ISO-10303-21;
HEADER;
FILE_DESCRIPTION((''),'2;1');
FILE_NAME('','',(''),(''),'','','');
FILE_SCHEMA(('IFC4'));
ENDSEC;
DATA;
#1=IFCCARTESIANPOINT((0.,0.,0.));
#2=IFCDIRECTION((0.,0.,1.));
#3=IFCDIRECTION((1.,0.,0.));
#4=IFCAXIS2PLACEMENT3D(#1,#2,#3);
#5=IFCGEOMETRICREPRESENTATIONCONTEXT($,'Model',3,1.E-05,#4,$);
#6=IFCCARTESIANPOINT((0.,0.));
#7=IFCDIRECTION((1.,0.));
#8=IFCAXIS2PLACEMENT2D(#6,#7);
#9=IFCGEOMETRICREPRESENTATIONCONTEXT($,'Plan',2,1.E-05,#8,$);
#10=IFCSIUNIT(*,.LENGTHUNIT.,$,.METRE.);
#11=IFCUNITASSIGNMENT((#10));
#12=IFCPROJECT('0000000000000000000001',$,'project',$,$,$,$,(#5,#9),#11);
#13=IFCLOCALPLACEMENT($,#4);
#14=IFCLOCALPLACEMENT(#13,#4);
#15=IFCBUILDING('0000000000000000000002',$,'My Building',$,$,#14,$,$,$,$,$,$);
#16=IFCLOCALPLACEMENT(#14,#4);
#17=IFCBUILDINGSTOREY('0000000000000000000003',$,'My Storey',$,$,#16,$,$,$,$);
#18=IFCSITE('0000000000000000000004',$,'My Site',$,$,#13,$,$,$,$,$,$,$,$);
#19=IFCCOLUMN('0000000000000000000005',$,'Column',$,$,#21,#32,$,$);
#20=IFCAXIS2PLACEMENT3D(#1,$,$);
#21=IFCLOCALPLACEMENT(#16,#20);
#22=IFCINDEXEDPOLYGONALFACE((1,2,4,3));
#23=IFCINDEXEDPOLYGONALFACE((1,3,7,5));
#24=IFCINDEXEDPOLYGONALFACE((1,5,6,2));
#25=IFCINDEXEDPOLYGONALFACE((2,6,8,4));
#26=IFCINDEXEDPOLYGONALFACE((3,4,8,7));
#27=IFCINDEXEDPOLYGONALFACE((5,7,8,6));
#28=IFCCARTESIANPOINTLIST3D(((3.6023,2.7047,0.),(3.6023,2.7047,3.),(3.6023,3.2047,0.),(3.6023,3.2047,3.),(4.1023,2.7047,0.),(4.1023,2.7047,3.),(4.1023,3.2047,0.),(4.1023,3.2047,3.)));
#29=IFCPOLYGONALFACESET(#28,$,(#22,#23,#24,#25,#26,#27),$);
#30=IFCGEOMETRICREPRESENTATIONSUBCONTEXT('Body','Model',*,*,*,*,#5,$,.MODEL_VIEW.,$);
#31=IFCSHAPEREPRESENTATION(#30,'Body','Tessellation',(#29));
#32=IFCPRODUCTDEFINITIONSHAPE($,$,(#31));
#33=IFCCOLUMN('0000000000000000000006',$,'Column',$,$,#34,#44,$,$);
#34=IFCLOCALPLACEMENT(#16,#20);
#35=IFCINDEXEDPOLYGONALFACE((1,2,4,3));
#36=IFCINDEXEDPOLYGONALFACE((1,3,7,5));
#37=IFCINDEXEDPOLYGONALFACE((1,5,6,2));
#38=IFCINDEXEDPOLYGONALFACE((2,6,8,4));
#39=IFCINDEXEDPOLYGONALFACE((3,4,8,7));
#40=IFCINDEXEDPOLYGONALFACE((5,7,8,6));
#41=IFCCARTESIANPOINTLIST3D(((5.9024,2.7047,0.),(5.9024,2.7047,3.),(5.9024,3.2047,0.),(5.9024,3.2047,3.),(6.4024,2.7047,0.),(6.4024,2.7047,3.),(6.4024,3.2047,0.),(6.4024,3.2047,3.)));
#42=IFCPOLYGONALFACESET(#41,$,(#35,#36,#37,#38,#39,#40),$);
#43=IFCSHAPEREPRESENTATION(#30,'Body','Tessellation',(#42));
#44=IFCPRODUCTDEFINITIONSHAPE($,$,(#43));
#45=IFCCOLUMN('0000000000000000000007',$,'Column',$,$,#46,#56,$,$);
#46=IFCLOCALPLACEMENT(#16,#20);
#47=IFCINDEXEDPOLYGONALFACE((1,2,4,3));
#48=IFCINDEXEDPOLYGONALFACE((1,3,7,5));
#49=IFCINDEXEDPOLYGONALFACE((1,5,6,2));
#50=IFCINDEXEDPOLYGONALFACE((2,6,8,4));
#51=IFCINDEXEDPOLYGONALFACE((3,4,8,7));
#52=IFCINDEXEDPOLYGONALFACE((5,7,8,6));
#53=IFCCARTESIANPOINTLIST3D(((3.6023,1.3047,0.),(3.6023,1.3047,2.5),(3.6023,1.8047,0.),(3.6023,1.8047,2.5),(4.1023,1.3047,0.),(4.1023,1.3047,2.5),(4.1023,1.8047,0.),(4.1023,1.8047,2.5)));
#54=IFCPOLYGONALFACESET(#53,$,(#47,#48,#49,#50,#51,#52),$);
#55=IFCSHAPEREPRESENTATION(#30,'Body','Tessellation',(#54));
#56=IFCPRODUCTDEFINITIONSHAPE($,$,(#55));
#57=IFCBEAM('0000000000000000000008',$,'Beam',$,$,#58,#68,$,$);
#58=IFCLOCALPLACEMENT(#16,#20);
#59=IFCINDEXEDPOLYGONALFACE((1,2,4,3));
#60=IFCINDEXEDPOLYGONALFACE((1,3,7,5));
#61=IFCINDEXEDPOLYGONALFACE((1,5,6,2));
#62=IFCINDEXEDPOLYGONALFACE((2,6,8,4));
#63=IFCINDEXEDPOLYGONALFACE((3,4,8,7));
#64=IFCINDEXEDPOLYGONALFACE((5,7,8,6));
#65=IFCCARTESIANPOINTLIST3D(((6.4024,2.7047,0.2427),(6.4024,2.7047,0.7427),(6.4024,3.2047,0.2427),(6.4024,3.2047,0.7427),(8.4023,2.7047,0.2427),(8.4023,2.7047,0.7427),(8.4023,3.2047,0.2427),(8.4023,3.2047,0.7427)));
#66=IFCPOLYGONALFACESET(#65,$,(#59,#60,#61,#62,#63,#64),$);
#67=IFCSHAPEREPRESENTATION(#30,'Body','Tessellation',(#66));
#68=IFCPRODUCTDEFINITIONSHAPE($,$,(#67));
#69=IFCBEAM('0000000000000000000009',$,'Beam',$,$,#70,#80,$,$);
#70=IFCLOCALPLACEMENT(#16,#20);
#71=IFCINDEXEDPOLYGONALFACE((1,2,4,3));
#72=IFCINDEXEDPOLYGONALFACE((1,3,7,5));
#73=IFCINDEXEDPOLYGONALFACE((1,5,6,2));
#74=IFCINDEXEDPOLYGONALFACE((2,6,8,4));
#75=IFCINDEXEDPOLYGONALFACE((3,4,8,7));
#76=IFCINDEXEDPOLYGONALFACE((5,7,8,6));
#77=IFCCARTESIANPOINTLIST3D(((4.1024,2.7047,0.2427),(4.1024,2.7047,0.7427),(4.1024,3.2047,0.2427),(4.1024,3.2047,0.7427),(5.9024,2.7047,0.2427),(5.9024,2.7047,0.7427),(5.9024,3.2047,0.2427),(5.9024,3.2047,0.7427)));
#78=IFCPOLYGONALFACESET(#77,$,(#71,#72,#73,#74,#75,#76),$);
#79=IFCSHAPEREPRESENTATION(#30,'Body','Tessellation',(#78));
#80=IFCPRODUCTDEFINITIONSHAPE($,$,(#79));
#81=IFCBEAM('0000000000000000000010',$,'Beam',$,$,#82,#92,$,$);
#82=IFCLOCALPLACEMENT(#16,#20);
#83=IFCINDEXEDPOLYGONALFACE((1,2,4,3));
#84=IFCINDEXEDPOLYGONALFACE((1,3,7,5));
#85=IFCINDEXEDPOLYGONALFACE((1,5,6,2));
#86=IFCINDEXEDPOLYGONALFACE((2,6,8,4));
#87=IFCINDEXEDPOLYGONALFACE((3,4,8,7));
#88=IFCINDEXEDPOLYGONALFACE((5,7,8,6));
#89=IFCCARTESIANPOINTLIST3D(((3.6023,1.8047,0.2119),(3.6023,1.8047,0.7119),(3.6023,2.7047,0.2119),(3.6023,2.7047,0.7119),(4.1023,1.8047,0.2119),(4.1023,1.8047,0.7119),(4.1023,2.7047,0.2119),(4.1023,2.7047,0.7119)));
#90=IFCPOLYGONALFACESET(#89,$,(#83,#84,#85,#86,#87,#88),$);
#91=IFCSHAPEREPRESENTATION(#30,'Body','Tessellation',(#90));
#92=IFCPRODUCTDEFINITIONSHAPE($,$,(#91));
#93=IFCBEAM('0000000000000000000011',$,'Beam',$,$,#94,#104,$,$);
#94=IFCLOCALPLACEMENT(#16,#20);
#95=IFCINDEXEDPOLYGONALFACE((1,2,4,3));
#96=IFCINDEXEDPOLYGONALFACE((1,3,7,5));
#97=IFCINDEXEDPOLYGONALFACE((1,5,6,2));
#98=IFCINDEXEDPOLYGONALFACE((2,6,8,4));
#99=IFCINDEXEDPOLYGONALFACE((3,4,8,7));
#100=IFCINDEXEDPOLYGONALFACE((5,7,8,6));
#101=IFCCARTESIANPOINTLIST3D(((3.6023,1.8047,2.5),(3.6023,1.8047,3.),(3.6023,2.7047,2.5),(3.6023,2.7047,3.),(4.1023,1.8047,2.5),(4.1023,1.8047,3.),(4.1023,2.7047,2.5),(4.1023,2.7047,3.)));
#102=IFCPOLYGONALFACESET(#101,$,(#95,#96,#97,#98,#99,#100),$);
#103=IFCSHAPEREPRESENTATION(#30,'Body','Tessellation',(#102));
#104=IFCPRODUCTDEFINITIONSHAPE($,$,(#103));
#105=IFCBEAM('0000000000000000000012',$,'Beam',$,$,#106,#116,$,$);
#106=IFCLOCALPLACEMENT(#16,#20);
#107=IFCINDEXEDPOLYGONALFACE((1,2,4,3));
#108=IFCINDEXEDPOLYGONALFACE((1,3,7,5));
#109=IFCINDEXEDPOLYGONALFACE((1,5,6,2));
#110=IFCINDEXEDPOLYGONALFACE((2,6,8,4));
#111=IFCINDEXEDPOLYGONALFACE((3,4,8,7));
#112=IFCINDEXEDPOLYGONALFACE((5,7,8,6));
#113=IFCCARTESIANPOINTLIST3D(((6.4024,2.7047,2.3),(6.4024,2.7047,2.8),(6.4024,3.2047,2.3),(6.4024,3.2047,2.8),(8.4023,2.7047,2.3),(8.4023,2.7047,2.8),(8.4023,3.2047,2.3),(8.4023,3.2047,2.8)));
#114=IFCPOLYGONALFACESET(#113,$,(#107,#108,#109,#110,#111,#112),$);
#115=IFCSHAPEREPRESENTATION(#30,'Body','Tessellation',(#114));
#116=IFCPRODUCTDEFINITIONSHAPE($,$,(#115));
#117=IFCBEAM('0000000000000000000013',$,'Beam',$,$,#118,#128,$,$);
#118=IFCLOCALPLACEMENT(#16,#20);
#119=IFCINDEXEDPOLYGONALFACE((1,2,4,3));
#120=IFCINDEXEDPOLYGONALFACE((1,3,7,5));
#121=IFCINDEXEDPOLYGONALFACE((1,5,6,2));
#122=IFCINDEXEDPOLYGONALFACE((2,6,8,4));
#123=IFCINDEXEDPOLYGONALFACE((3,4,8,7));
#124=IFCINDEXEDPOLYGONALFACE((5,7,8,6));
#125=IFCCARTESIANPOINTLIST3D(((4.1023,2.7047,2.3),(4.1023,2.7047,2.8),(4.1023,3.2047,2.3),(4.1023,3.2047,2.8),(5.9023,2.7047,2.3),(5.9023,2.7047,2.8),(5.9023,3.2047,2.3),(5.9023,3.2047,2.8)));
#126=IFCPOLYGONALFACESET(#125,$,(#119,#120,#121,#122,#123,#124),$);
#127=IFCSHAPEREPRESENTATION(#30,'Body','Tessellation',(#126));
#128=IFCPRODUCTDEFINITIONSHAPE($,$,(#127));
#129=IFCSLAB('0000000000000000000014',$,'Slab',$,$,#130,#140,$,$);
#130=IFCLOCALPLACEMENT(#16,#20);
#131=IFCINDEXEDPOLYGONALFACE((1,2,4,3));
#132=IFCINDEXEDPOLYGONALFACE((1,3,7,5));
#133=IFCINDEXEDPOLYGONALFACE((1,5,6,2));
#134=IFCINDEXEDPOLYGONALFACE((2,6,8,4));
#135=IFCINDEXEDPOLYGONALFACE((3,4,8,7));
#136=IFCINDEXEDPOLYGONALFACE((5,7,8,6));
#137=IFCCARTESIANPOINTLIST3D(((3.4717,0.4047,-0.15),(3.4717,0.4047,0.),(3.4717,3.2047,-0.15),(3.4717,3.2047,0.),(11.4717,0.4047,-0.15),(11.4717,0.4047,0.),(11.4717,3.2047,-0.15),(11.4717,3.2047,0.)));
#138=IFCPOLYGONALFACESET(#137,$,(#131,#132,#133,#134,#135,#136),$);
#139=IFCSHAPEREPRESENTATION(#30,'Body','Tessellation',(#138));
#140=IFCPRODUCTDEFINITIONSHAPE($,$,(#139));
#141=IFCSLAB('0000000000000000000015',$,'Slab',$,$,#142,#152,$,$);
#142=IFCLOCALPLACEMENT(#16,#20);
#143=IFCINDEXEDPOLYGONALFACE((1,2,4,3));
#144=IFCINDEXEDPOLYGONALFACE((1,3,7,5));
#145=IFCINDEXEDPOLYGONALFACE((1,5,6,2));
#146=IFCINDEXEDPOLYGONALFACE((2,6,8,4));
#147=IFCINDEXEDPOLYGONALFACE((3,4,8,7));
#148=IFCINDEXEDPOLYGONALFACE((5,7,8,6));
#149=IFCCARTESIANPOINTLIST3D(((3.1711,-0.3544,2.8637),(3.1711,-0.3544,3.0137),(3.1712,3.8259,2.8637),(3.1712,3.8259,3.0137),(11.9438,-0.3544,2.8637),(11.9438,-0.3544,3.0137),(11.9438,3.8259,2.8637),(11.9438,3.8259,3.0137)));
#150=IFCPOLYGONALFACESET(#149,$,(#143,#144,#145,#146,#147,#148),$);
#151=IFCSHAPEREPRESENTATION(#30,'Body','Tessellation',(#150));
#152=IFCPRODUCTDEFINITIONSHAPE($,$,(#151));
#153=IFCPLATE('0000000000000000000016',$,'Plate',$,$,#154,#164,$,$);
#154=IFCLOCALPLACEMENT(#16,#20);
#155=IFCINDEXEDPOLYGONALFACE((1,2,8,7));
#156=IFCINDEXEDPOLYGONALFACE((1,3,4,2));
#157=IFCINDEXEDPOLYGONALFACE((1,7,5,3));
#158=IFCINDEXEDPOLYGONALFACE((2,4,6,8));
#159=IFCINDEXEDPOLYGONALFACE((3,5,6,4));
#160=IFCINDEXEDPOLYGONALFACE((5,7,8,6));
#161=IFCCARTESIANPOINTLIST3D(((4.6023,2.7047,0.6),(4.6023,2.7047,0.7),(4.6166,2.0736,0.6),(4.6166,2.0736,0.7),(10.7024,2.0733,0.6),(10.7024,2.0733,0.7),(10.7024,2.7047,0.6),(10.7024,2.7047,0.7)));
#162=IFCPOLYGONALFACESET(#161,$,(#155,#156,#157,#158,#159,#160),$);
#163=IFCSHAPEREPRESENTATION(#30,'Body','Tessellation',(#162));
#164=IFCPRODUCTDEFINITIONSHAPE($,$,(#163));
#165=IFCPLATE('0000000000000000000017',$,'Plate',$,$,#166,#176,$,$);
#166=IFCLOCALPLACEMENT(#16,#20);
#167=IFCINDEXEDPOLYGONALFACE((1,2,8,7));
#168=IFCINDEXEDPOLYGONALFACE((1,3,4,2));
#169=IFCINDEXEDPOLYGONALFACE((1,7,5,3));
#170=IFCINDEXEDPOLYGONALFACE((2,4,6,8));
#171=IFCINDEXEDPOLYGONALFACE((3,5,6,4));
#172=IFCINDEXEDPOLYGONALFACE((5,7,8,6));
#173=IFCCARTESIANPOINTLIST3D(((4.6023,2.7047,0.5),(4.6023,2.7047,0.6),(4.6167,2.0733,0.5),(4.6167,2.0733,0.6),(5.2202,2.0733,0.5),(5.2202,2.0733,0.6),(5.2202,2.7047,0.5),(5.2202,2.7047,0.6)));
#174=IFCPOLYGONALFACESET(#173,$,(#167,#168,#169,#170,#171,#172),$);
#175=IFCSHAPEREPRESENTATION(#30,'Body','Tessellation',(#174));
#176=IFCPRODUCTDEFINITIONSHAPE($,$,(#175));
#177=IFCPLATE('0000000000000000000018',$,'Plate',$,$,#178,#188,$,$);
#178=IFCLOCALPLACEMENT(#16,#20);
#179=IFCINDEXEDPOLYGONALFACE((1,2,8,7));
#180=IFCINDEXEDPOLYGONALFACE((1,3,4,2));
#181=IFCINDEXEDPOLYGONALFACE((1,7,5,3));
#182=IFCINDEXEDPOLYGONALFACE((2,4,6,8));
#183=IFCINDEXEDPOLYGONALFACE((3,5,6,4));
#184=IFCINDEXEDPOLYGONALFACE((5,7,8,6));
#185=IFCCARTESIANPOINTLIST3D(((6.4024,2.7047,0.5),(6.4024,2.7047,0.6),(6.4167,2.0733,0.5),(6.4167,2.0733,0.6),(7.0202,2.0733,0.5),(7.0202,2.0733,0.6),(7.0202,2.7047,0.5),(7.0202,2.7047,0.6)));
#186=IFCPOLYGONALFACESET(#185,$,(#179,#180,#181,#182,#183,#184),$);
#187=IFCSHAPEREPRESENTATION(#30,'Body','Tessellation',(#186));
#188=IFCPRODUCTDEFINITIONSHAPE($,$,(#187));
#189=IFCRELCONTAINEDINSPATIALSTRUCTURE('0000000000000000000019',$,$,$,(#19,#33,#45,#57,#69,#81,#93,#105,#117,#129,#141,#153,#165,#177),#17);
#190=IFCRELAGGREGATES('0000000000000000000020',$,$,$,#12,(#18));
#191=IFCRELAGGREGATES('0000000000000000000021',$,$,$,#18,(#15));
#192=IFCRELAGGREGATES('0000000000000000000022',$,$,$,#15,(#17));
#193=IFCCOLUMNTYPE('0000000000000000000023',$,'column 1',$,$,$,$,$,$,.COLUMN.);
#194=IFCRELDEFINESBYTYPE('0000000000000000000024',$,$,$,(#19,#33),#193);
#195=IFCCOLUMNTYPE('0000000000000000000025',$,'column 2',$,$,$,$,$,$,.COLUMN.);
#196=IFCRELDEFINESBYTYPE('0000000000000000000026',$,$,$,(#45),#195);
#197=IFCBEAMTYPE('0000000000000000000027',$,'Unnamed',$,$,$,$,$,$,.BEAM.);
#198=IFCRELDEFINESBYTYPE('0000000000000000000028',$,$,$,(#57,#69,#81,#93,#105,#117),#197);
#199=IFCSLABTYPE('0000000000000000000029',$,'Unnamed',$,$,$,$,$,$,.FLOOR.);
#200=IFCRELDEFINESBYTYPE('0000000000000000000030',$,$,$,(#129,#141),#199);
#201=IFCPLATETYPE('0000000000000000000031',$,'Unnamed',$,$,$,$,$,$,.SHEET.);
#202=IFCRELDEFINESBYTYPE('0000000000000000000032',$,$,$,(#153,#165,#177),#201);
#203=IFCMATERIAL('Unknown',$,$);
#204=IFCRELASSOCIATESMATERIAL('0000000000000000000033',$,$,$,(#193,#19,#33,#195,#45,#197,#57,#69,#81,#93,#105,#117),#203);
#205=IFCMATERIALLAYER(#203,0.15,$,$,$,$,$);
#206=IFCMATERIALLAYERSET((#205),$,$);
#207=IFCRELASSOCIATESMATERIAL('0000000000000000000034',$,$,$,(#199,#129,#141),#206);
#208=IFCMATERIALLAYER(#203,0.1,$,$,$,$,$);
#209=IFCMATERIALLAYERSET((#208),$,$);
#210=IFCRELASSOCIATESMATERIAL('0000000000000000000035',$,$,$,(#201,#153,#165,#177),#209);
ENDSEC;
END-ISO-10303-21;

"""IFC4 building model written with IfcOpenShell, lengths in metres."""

from ifc_helpers import new_model, si_unit, frame, origin_with_axes, origin_2d_with_axis, place, context, subcontext, project, spatial, indexed_curve, rectangle, outline, extrude, material, layer, layer_set, layer_usage, material_profile, profile_set, profile_usage, type_object, element, save


model = new_model("IFC4")

# Units and contexts
model_context = context("Model", 3, precision=1e-05, world=origin_with_axes())
plan_context = context("Plan", 2, precision=1e-05, world=origin_2d_with_axis())
body_context = subcontext(model_context, "Body", "Model", "MODEL_VIEW")
ifc_project = project(units=[si_unit("LENGTHUNIT", "METRE")], contexts=[model_context, plan_context])

# Site, building, storey
site_placement = place(None, origin_with_axes())
site = spatial("IfcSite", under=ifc_project, at=site_placement, Name="My Site")
building_placement = place(site_placement, origin_with_axes())
building = spatial("IfcBuilding", under=site, at=building_placement, Name="My Building")
storey_placement = place(building_placement, origin_with_axes())
storey = spatial("IfcBuildingStorey", under=building, at=storey_placement, Name="My Storey")

# Columns
ifc_material = material(Name="Unknown")
ifc_material_profile_1 = material_profile(ifc_material, rectangle(XDim=0.5, YDim=0.5))
ifc_profile_set_1 = profile_set([ifc_material_profile_1])
ifc_profile_usage_1 = profile_usage(ifc_profile_set_1, cardinal=5)
column_type_1 = type_object("IfcColumnType", Name="column 1", PredefinedType="COLUMN", material=ifc_profile_set_1)
column_1_placement = place(storey_placement, frame((3.8523, 2.9547, 0.0), z_axis=(0.0, 0.0, 1.0), x_axis=(1.0, 0.0, 0.0)))
element("IfcColumn", 1, at=column_1_placement, inside=storey, type_object=column_type_1, material=ifc_profile_usage_1, Name="Column", context=body_context, shape_type="SweptSolid", body=[
    extrude(rectangle(XDim=0.5, YDim=0.5), origin_with_axes(), (0.0, 0.0, 1.0), 3.0),
])
ifc_profile_usage_2 = profile_usage(ifc_profile_set_1, cardinal=5)
column_2_placement = place(storey_placement, frame((6.1524, 2.9547, 0.0), z_axis=(0.0, 0.0, 1.0), x_axis=(1.0, 0.0, 0.0)))
element("IfcColumn", 2, at=column_2_placement, inside=storey, type_object=column_type_1, material=ifc_profile_usage_2, Name="Column", context=body_context, shape_type="SweptSolid", body=[
    extrude(rectangle(XDim=0.5, YDim=0.5), origin_with_axes(), (0.0, 0.0, 1.0), 3.0),
])
ifc_material_profile_2 = material_profile(ifc_material, rectangle(XDim=0.5, YDim=0.5))
ifc_profile_set_2 = profile_set([ifc_material_profile_2])
ifc_profile_usage_3 = profile_usage(ifc_profile_set_2, cardinal=5)
column_type_2 = type_object("IfcColumnType", Name="column 2", PredefinedType="COLUMN", material=ifc_profile_set_2)
column_3_placement = place(storey_placement, frame((3.8523, 1.5547, 0.0), z_axis=(0.0, 0.0, 1.0), x_axis=(1.0, 0.0, 0.0)))
element("IfcColumn", 3, at=column_3_placement, inside=storey, type_object=column_type_2, material=ifc_profile_usage_3, Name="Column", context=body_context, shape_type="SweptSolid", body=[
    extrude(rectangle(XDim=0.5, YDim=0.5), origin_with_axes(), (0.0, 0.0, 1.0), 2.5),
])

# Beams
ifc_material_profile_3 = material_profile(ifc_material, rectangle(XDim=0.5, YDim=0.5))
ifc_profile_set_3 = profile_set([ifc_material_profile_3])
ifc_profile_usage_4 = profile_usage(ifc_profile_set_3, cardinal=5)
beam_type = type_object("IfcBeamType", Name="Unnamed", PredefinedType="BEAM", material=ifc_profile_set_3)
beam_1_placement = place(storey_placement, frame((6.4024, 2.9547, 0.4927), z_axis=(1.0, 0.0, 0.0), x_axis=(0.0, 1.0, 0.0)))
element("IfcBeam", 4, at=beam_1_placement, inside=storey, type_object=beam_type, material=ifc_profile_usage_4, Name="Beam", context=body_context, shape_type="SweptSolid", body=[
    extrude(rectangle(XDim=0.5, YDim=0.5), origin_with_axes(), (0.0, 0.0, 1.0), 2.0),
])
ifc_profile_usage_5 = profile_usage(ifc_profile_set_3, cardinal=5)
beam_2_placement = place(storey_placement, frame((5.9024, 2.9547, 0.4927), z_axis=(-1.0, 0.0, 0.0), x_axis=(0.0, -1.0, 0.0)))
element("IfcBeam", 5, at=beam_2_placement, inside=storey, type_object=beam_type, material=ifc_profile_usage_5, Name="Beam", context=body_context, shape_type="SweptSolid", body=[
    extrude(rectangle(XDim=0.5, YDim=0.5), origin_with_axes(), (0.0, 0.0, 1.0), 1.8),
])
ifc_profile_usage_6 = profile_usage(ifc_profile_set_3, cardinal=5)
beam_3_placement = place(storey_placement, frame((3.8523, 2.7047, 0.4619), z_axis=(0.0, -1.0, 0.0), x_axis=(1.0, 0.0, 0.0)))
element("IfcBeam", 6, at=beam_3_placement, inside=storey, type_object=beam_type, material=ifc_profile_usage_6, Name="Beam", context=body_context, shape_type="SweptSolid", body=[
    extrude(rectangle(XDim=0.5, YDim=0.5), origin_with_axes(), (0.0, 0.0, 1.0), 0.9),
])
ifc_profile_usage_7 = profile_usage(ifc_profile_set_3, cardinal=5)
beam_4_placement = place(storey_placement, frame((3.8523, 2.7047, 2.75), z_axis=(0.0, -1.0, 0.0), x_axis=(1.0, 0.0, 0.0)))
element("IfcBeam", 7, at=beam_4_placement, inside=storey, type_object=beam_type, material=ifc_profile_usage_7, Name="Beam", context=body_context, shape_type="SweptSolid", body=[
    extrude(rectangle(XDim=0.5, YDim=0.5), origin_with_axes(), (0.0, 0.0, 1.0), 0.9),
])
ifc_profile_usage_8 = profile_usage(ifc_profile_set_3, cardinal=5)
beam_5_placement = place(storey_placement, frame((6.4024, 2.9547, 2.55), z_axis=(1.0, 0.0, 0.0), x_axis=(0.0, 1.0, 0.0)))
element("IfcBeam", 8, at=beam_5_placement, inside=storey, type_object=beam_type, material=ifc_profile_usage_8, Name="Beam", context=body_context, shape_type="SweptSolid", body=[
    extrude(rectangle(XDim=0.5, YDim=0.5), origin_with_axes(), (0.0, 0.0, 1.0), 2.0),
])
ifc_profile_usage_9 = profile_usage(ifc_profile_set_3, cardinal=5)
beam_6_placement = place(storey_placement, frame((4.1023, 2.9547, 2.55), z_axis=(1.0, 0.0, 0.0), x_axis=(0.0, 1.0, 0.0)))
element("IfcBeam", 9, at=beam_6_placement, inside=storey, type_object=beam_type, material=ifc_profile_usage_9, Name="Beam", context=body_context, shape_type="SweptSolid", body=[
    extrude(rectangle(XDim=0.5, YDim=0.5), origin_with_axes(), (0.0, 0.0, 1.0), 1.7999),
])

# Slabs
ifc_layer_1 = layer(ifc_material, 0.15)
ifc_layer_set_1 = layer_set([ifc_layer_1])
ifc_layer_usage_1 = layer_usage(ifc_layer_set_1, "AXIS3", "POSITIVE", -0.15)
slab_type = type_object("IfcSlabType", Name="Unnamed", PredefinedType="FLOOR", material=ifc_layer_set_1)
slab_1_placement = place(storey_placement, frame((3.4717, 3.2047, 0.0), z_axis=(0.0, 0.0, 1.0), x_axis=(1.0, 0.0, 0.0)))
element("IfcSlab", 10, at=slab_1_placement, inside=storey, type_object=slab_type, material=ifc_layer_usage_1, Name="Slab", context=body_context, shape_type="SweptSolid", body=[
    extrude(outline(indexed_curve([(0.0, 0.0), (8.0, 0.0), (8.0, -2.8), (0.0, -2.8), (0.0, 0.0)])), frame((0.0, 0.0, -0.15), z_axis=(0.0, 0.0, 1.0), x_axis=(1.0, 0.0, 0.0)), (0.0, 0.0, 1.0), 0.15),
])
ifc_layer_usage_2 = layer_usage(ifc_layer_set_1, "AXIS3", "POSITIVE", -0.15)
slab_2_placement = place(storey_placement, frame((3.1712, 3.8259, 3.0137), z_axis=(0.0, 0.0, 1.0), x_axis=(1.0, 0.0, 0.0)))
element("IfcSlab", 11, at=slab_2_placement, inside=storey, type_object=slab_type, material=ifc_layer_usage_2, Name="Slab", context=body_context, shape_type="SweptSolid", body=[
    extrude(outline(indexed_curve([(0.0, 0.0), (8.7726, 0.0), (8.7726, -4.1803), (0.0, -4.1803), (0.0, 0.0)])), frame((0.0, 0.0, -0.15), z_axis=(0.0, 0.0, 1.0), x_axis=(1.0, 0.0, 0.0)), (0.0, 0.0, 1.0), 0.15),
])

# Plates
ifc_layer_2 = layer(ifc_material, 0.1)
ifc_layer_set_2 = layer_set([ifc_layer_2])
ifc_layer_usage_3 = layer_usage(ifc_layer_set_2, "AXIS3", "POSITIVE", -0.1)
plate_type = type_object("IfcPlateType", Name="Unnamed", PredefinedType="SHEET", material=ifc_layer_set_2)
plate_1_placement = place(storey_placement, frame((4.6023, 2.0733, 0.7), z_axis=(0.0, 0.0, 1.0), x_axis=(1.0, 0.0, 0.0)))
element("IfcPlate", 12, at=plate_1_placement, inside=storey, type_object=plate_type, material=ifc_layer_usage_3, Name="Plate", context=body_context, shape_type="SweptSolid", body=[
    extrude(outline(indexed_curve([(0.0, 0.6314), (6.1, 0.6314), (6.1, 0.0), (0.0143, 0.0003), (0.0, 0.6314)])), frame((0.0, 0.0, -0.1), z_axis=(0.0, 0.0, 1.0), x_axis=(1.0, 0.0, 0.0)), (0.0, 0.0, 1.0), 0.1),
])
ifc_layer_usage_4 = layer_usage(ifc_layer_set_2, "AXIS3", "POSITIVE", -0.1)
plate_2_placement = place(storey_placement, frame((4.6167, 2.0733, 0.6), z_axis=(0.0, 0.0, 1.0), x_axis=(1.0, 0.0, 0.0)))
element("IfcPlate", 13, at=plate_2_placement, inside=storey, type_object=plate_type, material=ifc_layer_usage_4, Name="Plate", context=body_context, shape_type="SweptSolid", body=[
    extrude(outline(indexed_curve([(0.0, 0.0), (0.6036, 0.0), (0.6036, 0.6314), (-0.0143, 0.6314), (0.0, 0.0)])), frame((0.0, 0.0, -0.1), z_axis=(0.0, 0.0, 1.0), x_axis=(1.0, 0.0, 0.0)), (0.0, 0.0, 1.0), 0.1),
])
ifc_layer_usage_5 = layer_usage(ifc_layer_set_2, "AXIS3", "POSITIVE", -0.1)
plate_3_placement = place(storey_placement, frame((6.4167, 2.0733, 0.6), z_axis=(0.0, 0.0, 1.0), x_axis=(1.0, 0.0, 0.0)))
element("IfcPlate", 14, at=plate_3_placement, inside=storey, type_object=plate_type, material=ifc_layer_usage_5, Name="Plate", context=body_context, shape_type="SweptSolid", body=[
    extrude(outline(indexed_curve([(0.0, 0.0), (0.6036, 0.0), (0.6036, 0.6314), (-0.0143, 0.6314), (0.0, 0.0)])), frame((0.0, 0.0, -0.1), z_axis=(0.0, 0.0, 1.0), x_axis=(1.0, 0.0, 0.0)), (0.0, 0.0, 1.0), 0.1),
])

save(model, "model.ifc")
